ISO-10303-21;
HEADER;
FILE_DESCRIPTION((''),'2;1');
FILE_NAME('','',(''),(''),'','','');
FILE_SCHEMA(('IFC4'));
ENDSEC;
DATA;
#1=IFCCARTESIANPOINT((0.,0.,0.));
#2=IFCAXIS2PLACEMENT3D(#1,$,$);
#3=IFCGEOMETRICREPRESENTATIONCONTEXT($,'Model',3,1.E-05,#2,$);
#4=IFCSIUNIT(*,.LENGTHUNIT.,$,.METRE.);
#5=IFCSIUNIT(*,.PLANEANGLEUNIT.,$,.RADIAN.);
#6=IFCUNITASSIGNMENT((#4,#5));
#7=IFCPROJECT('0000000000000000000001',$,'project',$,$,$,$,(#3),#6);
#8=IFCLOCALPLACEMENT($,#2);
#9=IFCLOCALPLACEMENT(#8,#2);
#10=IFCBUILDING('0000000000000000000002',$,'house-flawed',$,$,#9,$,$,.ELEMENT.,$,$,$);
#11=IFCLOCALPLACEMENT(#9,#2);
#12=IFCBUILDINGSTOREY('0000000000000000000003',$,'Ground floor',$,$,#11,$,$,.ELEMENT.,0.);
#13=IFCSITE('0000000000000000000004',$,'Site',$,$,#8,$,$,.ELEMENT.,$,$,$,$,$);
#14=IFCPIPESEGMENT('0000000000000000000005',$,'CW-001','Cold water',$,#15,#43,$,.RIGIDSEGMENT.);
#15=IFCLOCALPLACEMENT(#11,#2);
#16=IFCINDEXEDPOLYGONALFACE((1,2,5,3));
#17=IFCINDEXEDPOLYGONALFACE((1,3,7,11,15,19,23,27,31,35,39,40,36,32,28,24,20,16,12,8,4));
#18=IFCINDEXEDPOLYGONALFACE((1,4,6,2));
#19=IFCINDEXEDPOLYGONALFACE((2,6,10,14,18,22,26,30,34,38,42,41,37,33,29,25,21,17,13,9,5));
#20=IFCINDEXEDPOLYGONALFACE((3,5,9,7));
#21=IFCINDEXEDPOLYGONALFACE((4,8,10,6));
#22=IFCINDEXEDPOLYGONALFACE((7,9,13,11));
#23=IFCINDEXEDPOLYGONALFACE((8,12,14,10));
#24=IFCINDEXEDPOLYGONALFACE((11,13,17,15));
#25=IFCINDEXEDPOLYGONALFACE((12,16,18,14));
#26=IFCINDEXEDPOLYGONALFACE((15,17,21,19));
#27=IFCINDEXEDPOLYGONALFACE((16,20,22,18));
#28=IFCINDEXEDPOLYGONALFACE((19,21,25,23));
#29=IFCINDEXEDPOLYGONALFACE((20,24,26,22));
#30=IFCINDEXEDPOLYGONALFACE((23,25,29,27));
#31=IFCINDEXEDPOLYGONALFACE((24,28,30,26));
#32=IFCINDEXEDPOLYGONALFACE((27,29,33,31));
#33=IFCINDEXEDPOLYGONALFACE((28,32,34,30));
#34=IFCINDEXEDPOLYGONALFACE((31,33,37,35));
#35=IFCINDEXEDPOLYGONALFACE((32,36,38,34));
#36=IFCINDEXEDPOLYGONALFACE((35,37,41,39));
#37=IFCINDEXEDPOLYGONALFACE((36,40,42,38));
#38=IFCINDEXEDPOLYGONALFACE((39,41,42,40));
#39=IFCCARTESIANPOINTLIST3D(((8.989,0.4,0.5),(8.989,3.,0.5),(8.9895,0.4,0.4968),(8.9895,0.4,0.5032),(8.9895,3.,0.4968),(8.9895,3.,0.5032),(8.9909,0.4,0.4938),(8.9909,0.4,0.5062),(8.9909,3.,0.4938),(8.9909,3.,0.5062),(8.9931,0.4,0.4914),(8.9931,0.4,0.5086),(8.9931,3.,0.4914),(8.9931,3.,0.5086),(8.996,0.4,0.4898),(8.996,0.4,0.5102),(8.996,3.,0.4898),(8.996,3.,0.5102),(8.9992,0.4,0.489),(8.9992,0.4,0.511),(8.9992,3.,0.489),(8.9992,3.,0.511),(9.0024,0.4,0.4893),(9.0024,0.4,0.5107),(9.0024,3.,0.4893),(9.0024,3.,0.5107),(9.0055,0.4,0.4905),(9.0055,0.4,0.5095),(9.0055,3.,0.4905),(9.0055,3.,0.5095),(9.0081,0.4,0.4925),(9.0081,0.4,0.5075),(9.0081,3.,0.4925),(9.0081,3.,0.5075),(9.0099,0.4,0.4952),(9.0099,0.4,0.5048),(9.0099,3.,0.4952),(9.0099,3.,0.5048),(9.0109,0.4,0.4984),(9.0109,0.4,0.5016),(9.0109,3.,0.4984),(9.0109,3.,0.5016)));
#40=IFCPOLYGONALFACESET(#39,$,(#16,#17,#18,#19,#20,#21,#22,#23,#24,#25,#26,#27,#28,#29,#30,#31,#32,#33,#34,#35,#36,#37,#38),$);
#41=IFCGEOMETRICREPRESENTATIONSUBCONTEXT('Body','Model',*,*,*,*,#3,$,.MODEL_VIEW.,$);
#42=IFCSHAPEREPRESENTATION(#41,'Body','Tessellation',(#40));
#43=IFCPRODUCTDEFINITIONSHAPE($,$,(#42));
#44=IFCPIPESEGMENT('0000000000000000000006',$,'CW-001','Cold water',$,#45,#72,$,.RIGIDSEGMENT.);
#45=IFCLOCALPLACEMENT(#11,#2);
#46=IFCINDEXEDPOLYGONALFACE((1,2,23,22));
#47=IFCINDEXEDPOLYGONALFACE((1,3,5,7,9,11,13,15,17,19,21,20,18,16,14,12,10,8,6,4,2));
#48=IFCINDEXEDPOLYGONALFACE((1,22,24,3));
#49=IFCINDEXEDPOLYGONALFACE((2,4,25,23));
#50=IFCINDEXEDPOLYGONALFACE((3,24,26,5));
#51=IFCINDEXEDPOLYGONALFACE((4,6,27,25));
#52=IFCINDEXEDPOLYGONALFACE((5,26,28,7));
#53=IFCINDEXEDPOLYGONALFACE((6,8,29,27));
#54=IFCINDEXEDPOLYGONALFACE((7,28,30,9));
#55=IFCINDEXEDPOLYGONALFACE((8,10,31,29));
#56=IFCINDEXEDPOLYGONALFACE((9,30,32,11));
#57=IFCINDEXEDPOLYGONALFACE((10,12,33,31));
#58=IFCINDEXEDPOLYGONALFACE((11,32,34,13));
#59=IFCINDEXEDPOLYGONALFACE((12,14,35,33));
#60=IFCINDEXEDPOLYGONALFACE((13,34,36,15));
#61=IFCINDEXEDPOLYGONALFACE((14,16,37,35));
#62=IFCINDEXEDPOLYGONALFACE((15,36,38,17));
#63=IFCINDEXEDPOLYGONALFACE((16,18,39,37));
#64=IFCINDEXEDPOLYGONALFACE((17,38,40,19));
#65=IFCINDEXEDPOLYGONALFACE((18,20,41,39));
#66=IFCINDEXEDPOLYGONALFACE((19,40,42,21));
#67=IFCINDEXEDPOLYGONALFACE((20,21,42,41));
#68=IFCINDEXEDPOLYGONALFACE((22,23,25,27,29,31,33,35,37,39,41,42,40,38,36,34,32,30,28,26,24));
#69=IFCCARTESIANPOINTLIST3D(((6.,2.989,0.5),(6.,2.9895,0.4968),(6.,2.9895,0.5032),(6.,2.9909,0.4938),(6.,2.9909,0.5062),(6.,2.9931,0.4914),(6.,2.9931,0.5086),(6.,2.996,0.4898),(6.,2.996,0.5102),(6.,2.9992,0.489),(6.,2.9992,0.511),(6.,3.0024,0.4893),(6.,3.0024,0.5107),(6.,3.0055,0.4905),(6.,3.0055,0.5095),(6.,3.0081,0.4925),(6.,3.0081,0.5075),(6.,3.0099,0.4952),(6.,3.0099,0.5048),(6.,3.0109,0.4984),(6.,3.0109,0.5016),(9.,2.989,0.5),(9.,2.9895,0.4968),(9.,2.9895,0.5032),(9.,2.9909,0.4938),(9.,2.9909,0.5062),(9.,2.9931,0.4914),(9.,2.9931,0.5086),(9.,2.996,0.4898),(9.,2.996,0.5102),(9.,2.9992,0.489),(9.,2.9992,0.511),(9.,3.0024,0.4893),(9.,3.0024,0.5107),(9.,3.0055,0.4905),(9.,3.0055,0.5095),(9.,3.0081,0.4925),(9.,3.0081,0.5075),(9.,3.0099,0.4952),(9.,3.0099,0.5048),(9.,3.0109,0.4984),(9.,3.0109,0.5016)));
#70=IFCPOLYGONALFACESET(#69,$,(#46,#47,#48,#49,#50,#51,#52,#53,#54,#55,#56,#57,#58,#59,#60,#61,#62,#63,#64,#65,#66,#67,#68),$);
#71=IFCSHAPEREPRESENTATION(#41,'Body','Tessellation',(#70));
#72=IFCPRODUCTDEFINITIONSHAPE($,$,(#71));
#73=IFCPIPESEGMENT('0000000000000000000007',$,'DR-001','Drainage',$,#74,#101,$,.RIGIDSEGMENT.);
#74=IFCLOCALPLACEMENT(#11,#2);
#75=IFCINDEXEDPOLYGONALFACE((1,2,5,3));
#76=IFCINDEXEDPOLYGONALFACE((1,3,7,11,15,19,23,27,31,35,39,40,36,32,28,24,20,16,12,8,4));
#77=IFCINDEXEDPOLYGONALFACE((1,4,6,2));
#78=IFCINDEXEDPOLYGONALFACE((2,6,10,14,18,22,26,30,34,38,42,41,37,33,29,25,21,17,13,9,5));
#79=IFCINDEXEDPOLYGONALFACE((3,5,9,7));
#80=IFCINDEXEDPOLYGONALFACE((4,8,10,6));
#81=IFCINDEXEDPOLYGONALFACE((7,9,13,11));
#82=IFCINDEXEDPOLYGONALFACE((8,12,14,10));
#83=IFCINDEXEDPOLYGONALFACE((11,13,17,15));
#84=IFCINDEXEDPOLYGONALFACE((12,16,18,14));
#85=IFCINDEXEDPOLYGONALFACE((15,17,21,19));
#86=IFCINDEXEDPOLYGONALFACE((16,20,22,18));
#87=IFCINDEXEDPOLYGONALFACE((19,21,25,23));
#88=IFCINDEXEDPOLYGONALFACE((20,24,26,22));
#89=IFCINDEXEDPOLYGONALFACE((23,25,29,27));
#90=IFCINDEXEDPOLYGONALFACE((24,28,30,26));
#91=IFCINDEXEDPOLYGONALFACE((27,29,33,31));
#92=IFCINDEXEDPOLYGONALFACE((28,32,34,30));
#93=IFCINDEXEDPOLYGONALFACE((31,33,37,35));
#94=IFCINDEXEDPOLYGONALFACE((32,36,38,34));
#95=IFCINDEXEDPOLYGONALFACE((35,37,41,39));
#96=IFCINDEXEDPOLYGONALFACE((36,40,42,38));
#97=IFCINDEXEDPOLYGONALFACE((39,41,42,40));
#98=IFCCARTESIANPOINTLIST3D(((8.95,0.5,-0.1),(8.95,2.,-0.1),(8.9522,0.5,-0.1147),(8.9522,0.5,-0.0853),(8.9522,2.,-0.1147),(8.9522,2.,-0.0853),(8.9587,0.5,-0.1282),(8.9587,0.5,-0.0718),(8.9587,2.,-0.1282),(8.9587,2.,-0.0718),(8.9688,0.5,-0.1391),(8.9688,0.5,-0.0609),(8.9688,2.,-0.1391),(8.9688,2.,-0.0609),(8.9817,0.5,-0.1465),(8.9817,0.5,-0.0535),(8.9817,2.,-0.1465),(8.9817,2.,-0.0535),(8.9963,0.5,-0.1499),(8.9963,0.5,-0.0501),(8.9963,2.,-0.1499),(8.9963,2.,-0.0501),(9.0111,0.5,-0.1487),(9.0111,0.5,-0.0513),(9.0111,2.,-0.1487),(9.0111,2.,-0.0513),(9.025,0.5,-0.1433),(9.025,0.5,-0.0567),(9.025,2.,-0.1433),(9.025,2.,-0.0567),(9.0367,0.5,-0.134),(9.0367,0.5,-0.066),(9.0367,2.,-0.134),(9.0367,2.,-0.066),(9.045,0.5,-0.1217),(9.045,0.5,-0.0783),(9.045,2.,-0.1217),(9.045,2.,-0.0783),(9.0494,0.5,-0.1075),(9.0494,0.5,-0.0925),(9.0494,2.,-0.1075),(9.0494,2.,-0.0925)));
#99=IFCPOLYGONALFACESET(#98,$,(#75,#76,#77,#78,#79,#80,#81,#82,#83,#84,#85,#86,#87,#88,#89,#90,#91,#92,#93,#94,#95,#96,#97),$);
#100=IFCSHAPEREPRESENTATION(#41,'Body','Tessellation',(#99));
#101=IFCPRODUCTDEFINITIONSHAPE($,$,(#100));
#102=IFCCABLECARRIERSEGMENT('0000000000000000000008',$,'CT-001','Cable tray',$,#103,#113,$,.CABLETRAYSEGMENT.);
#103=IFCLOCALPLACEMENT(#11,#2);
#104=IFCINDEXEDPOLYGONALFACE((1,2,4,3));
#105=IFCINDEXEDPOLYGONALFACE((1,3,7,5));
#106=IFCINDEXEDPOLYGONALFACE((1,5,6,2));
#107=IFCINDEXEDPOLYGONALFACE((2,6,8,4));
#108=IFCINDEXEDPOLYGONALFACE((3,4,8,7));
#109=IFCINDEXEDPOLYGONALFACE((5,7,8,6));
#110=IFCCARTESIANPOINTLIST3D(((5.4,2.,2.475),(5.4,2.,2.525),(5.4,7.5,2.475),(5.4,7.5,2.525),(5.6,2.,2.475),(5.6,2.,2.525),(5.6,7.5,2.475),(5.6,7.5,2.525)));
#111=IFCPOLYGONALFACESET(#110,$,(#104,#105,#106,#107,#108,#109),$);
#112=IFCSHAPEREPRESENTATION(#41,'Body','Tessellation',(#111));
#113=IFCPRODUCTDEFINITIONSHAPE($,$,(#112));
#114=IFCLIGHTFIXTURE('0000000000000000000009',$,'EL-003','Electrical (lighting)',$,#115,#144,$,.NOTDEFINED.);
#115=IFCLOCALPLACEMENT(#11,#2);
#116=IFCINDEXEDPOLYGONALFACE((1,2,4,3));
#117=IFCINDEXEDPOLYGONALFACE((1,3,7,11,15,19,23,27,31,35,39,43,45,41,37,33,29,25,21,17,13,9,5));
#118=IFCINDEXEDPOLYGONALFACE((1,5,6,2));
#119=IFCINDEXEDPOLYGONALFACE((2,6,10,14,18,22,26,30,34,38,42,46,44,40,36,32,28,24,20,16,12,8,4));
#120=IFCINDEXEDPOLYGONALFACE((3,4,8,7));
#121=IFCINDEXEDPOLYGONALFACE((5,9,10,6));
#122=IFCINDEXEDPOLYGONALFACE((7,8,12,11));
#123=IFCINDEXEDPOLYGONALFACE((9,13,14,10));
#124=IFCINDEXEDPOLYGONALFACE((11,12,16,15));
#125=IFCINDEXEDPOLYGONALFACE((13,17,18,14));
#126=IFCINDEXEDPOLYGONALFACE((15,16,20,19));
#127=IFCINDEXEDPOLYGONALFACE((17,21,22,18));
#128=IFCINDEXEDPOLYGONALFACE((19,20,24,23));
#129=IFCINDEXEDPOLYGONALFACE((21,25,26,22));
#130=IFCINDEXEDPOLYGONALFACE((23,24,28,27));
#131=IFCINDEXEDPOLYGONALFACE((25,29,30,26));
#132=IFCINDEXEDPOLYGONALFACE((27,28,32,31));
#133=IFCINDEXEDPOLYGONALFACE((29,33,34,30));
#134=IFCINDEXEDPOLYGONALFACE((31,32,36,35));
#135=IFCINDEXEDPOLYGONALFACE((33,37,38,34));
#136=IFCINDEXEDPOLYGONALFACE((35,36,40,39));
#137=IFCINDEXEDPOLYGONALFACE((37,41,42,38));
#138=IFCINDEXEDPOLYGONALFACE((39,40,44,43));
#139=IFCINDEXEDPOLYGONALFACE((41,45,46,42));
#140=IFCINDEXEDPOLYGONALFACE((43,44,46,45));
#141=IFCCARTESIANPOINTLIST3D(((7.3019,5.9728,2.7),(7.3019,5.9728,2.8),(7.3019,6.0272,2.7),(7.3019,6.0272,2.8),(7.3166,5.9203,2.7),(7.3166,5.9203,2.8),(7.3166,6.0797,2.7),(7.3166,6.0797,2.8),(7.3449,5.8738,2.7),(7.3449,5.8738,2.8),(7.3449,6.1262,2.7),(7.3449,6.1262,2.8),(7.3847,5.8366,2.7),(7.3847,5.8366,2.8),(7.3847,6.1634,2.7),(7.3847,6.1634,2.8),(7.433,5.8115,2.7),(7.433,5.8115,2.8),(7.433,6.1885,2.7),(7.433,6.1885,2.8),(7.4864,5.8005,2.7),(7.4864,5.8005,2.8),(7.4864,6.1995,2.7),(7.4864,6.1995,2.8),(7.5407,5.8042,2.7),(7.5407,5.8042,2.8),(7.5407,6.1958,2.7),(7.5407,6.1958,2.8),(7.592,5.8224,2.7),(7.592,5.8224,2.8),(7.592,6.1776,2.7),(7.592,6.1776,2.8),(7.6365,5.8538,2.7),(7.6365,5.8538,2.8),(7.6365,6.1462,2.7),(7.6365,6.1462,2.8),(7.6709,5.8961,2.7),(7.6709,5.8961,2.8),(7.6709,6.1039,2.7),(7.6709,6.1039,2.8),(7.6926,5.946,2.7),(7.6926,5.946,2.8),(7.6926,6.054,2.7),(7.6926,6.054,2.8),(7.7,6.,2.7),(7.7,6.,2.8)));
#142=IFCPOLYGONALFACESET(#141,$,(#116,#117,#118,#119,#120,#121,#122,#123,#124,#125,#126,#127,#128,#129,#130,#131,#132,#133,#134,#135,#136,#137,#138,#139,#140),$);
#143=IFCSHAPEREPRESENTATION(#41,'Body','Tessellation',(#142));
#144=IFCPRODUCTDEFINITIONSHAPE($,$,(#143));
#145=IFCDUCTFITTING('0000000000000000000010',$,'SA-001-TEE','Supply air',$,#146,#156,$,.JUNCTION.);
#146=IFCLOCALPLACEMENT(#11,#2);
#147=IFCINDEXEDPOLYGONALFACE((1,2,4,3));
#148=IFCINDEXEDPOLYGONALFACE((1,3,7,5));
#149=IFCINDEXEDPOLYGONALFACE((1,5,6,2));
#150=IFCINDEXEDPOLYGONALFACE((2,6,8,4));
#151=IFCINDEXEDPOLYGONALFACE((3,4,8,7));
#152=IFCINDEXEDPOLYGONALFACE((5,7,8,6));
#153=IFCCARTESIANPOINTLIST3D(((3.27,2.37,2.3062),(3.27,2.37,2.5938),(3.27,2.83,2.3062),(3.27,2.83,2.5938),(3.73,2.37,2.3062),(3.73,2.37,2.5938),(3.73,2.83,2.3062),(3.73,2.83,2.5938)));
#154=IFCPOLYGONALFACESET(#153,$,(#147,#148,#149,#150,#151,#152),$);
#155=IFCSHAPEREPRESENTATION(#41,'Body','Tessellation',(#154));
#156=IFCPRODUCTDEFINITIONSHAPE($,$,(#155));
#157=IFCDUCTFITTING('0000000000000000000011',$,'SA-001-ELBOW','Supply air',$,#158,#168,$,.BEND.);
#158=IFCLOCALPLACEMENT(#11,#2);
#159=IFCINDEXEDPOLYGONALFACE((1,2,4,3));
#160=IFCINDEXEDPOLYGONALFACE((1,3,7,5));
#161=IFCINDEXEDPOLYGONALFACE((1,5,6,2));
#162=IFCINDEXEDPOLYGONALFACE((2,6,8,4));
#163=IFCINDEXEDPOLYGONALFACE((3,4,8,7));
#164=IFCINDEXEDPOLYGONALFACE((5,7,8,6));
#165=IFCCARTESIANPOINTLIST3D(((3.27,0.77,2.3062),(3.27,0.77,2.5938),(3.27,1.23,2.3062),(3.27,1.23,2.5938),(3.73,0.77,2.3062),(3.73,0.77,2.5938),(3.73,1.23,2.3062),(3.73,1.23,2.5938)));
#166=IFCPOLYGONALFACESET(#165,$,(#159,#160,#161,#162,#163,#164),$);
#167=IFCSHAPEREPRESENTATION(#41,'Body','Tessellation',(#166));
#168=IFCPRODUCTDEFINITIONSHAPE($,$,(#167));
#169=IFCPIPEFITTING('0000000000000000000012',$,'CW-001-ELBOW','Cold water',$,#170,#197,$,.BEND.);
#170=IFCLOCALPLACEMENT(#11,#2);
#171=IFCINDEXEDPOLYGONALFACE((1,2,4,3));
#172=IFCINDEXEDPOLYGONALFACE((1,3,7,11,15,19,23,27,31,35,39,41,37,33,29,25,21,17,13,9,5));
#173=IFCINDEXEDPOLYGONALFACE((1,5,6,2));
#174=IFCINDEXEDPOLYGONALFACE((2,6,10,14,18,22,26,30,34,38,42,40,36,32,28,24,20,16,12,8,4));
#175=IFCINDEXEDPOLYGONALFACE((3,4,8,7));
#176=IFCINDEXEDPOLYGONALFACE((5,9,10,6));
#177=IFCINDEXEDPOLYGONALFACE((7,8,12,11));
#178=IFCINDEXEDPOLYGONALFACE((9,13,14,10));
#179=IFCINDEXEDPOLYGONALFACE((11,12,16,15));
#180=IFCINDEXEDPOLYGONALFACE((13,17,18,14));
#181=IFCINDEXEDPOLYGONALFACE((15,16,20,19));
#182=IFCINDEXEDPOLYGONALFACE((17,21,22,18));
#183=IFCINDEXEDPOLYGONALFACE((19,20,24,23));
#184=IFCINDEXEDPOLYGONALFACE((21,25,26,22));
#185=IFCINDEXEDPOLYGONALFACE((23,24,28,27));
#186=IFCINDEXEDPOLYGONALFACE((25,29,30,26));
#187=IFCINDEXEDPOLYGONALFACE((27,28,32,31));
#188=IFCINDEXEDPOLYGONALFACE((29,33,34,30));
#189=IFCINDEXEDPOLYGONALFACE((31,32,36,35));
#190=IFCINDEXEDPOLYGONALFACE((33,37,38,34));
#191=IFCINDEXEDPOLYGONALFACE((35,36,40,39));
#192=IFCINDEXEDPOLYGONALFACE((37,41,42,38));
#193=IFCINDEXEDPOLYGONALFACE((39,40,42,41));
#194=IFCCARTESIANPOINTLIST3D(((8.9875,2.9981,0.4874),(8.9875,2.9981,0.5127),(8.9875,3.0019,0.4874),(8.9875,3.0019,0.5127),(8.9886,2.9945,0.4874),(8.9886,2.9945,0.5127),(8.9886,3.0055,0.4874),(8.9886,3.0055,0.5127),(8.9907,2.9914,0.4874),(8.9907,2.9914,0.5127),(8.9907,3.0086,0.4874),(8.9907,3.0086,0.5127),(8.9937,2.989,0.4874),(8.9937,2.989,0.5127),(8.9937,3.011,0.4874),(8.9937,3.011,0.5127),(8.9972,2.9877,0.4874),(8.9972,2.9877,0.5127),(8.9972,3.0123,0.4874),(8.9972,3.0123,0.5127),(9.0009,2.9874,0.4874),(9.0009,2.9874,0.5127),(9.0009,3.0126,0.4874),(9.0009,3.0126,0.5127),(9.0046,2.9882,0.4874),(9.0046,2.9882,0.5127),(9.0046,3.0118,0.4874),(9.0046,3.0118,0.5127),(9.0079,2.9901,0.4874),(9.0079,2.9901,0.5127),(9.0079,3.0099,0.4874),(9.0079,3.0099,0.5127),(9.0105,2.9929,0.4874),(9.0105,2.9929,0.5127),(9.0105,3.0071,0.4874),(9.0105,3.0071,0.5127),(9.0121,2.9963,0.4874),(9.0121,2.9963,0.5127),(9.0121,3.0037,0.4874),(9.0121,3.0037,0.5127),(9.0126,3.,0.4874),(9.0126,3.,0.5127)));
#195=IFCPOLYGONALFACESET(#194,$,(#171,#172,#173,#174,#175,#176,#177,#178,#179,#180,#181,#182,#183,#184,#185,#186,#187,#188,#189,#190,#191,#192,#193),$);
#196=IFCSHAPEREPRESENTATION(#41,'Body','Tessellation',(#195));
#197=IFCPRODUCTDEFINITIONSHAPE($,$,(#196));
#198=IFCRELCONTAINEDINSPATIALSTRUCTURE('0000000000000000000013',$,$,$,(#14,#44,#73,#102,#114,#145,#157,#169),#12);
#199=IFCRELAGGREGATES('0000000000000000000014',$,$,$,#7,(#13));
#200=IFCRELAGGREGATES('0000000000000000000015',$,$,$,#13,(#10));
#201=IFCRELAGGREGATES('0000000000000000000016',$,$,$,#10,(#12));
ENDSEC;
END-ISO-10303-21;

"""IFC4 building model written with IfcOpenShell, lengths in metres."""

from ifc_helpers import new_model, si_unit, frame, origin, origin_2d, place, context, subcontext, project, spatial, rectangle, circle, extrude, element, save


model = new_model("IFC4")

# Units and contexts
model_context = context("Model", 3, precision=1e-05, world=origin())
body_context = subcontext(model_context, "Body", "Model", "MODEL_VIEW")
ifc_project = project(units=[si_unit("LENGTHUNIT", "METRE"), si_unit("PLANEANGLEUNIT", "RADIAN")], contexts=[model_context])

# Site, building, storey
site_placement = place(None, origin())
site = spatial("IfcSite", under=ifc_project, at=site_placement, Name="Site", CompositionType="ELEMENT")
building_placement = place(site_placement, origin())
building = spatial("IfcBuilding", under=site, at=building_placement, Name="house-flawed", CompositionType="ELEMENT")
storey_placement = place(building_placement, origin())
storey = spatial("IfcBuildingStorey", under=building, at=storey_placement, Name="Ground floor", CompositionType="ELEMENT", Elevation=0.0)

# Pipe segments
pipe_segment_1_placement = place(storey_placement, frame((9.0, 0.4, 0.5), z_axis=(0.0, 1.0, 0.0), x_axis=(-1.0, 0.0, 0.0)))
element("IfcPipeSegment", 1, at=pipe_segment_1_placement, inside=storey, Name="CW-001", Description="Cold water", PredefinedType="RIGIDSEGMENT", context=body_context, shape_type="SweptSolid", body=[
    extrude(circle(Radius=0.011, at=origin_2d()), origin(), (0.0, 0.0, 1.0), 2.6),
])
pipe_segment_2_placement = place(storey_placement, frame((9.0, 3.0, 0.5), z_axis=(-1.0, 0.0, 0.0), x_axis=(0.0, -1.0, 0.0)))
element("IfcPipeSegment", 2, at=pipe_segment_2_placement, inside=storey, Name="CW-001", Description="Cold water", PredefinedType="RIGIDSEGMENT", context=body_context, shape_type="SweptSolid", body=[
    extrude(circle(Radius=0.011, at=origin_2d()), origin(), (0.0, 0.0, 1.0), 3.0),
])
pipe_segment_3_placement = place(storey_placement, frame((9.0, 0.5, -0.1), z_axis=(0.0, 1.0, 0.0), x_axis=(-1.0, 0.0, 0.0)))
element("IfcPipeSegment", 3, at=pipe_segment_3_placement, inside=storey, Name="DR-001", Description="Drainage", PredefinedType="RIGIDSEGMENT", context=body_context, shape_type="SweptSolid", body=[
    extrude(circle(Radius=0.05, at=origin_2d()), origin(), (0.0, 0.0, 1.0), 1.5),
])

# Cable carrier segment
cable_carrier_segment_placement = place(storey_placement, frame((5.5, 2.0, 2.5), z_axis=(0.0, 1.0, 0.0), x_axis=(-1.0, 0.0, 0.0)))
element("IfcCableCarrierSegment", 4, at=cable_carrier_segment_placement, inside=storey, Name="CT-001", Description="Cable tray", PredefinedType="CABLETRAYSEGMENT", context=body_context, shape_type="SweptSolid", body=[
    extrude(rectangle(XDim=0.2, YDim=0.05, at=origin_2d()), origin(), (0.0, 0.0, 1.0), 5.5),
])

# Light fixture
light_fixture_placement = place(storey_placement, frame((7.5, 6.0, 2.7), z_axis=(0.0, 0.0, 1.0), x_axis=(1.0, 0.0, 0.0)))
element("IfcLightFixture", 5, at=light_fixture_placement, inside=storey, Name="EL-003", Description="Electrical (lighting)", PredefinedType="NOTDEFINED", context=body_context, shape_type="SweptSolid", body=[
    extrude(circle(Radius=0.2, at=origin_2d()), origin(), (0.0, 0.0, 1.0), 0.1),
])

# Duct fittings
duct_fitting_1_placement = place(storey_placement, frame((3.5, 2.6, 2.3062), z_axis=(0.0, 0.0, 1.0), x_axis=(1.0, 0.0, 0.0)))
element("IfcDuctFitting", 6, at=duct_fitting_1_placement, inside=storey, Name="SA-001-TEE", Description="Supply air", PredefinedType="JUNCTION", context=body_context, shape_type="SweptSolid", body=[
    extrude(rectangle(XDim=0.46, YDim=0.46, at=origin_2d()), origin(), (0.0, 0.0, 1.0), 0.2875),
])
duct_fitting_2_placement = place(storey_placement, frame((3.5, 1.0, 2.3062), z_axis=(0.0, 0.0, 1.0), x_axis=(1.0, 0.0, 0.0)))
element("IfcDuctFitting", 7, at=duct_fitting_2_placement, inside=storey, Name="SA-001-ELBOW", Description="Supply air", PredefinedType="BEND", context=body_context, shape_type="SweptSolid", body=[
    extrude(rectangle(XDim=0.46, YDim=0.46, at=origin_2d()), origin(), (0.0, 0.0, 1.0), 0.2875),
])

# Pipe fitting
pipe_fitting_placement = place(storey_placement, frame((9.0, 3.0, 0.4874), z_axis=(0.0, 0.0, 1.0), x_axis=(1.0, 0.0, 0.0)))
element("IfcPipeFitting", 8, at=pipe_fitting_placement, inside=storey, Name="CW-001-ELBOW", Description="Cold water", PredefinedType="BEND", context=body_context, shape_type="SweptSolid", body=[
    extrude(circle(Radius=0.0126, at=origin_2d()), origin(), (0.0, 0.0, 1.0), 0.0253),
])

save(model, "model.ifc")
